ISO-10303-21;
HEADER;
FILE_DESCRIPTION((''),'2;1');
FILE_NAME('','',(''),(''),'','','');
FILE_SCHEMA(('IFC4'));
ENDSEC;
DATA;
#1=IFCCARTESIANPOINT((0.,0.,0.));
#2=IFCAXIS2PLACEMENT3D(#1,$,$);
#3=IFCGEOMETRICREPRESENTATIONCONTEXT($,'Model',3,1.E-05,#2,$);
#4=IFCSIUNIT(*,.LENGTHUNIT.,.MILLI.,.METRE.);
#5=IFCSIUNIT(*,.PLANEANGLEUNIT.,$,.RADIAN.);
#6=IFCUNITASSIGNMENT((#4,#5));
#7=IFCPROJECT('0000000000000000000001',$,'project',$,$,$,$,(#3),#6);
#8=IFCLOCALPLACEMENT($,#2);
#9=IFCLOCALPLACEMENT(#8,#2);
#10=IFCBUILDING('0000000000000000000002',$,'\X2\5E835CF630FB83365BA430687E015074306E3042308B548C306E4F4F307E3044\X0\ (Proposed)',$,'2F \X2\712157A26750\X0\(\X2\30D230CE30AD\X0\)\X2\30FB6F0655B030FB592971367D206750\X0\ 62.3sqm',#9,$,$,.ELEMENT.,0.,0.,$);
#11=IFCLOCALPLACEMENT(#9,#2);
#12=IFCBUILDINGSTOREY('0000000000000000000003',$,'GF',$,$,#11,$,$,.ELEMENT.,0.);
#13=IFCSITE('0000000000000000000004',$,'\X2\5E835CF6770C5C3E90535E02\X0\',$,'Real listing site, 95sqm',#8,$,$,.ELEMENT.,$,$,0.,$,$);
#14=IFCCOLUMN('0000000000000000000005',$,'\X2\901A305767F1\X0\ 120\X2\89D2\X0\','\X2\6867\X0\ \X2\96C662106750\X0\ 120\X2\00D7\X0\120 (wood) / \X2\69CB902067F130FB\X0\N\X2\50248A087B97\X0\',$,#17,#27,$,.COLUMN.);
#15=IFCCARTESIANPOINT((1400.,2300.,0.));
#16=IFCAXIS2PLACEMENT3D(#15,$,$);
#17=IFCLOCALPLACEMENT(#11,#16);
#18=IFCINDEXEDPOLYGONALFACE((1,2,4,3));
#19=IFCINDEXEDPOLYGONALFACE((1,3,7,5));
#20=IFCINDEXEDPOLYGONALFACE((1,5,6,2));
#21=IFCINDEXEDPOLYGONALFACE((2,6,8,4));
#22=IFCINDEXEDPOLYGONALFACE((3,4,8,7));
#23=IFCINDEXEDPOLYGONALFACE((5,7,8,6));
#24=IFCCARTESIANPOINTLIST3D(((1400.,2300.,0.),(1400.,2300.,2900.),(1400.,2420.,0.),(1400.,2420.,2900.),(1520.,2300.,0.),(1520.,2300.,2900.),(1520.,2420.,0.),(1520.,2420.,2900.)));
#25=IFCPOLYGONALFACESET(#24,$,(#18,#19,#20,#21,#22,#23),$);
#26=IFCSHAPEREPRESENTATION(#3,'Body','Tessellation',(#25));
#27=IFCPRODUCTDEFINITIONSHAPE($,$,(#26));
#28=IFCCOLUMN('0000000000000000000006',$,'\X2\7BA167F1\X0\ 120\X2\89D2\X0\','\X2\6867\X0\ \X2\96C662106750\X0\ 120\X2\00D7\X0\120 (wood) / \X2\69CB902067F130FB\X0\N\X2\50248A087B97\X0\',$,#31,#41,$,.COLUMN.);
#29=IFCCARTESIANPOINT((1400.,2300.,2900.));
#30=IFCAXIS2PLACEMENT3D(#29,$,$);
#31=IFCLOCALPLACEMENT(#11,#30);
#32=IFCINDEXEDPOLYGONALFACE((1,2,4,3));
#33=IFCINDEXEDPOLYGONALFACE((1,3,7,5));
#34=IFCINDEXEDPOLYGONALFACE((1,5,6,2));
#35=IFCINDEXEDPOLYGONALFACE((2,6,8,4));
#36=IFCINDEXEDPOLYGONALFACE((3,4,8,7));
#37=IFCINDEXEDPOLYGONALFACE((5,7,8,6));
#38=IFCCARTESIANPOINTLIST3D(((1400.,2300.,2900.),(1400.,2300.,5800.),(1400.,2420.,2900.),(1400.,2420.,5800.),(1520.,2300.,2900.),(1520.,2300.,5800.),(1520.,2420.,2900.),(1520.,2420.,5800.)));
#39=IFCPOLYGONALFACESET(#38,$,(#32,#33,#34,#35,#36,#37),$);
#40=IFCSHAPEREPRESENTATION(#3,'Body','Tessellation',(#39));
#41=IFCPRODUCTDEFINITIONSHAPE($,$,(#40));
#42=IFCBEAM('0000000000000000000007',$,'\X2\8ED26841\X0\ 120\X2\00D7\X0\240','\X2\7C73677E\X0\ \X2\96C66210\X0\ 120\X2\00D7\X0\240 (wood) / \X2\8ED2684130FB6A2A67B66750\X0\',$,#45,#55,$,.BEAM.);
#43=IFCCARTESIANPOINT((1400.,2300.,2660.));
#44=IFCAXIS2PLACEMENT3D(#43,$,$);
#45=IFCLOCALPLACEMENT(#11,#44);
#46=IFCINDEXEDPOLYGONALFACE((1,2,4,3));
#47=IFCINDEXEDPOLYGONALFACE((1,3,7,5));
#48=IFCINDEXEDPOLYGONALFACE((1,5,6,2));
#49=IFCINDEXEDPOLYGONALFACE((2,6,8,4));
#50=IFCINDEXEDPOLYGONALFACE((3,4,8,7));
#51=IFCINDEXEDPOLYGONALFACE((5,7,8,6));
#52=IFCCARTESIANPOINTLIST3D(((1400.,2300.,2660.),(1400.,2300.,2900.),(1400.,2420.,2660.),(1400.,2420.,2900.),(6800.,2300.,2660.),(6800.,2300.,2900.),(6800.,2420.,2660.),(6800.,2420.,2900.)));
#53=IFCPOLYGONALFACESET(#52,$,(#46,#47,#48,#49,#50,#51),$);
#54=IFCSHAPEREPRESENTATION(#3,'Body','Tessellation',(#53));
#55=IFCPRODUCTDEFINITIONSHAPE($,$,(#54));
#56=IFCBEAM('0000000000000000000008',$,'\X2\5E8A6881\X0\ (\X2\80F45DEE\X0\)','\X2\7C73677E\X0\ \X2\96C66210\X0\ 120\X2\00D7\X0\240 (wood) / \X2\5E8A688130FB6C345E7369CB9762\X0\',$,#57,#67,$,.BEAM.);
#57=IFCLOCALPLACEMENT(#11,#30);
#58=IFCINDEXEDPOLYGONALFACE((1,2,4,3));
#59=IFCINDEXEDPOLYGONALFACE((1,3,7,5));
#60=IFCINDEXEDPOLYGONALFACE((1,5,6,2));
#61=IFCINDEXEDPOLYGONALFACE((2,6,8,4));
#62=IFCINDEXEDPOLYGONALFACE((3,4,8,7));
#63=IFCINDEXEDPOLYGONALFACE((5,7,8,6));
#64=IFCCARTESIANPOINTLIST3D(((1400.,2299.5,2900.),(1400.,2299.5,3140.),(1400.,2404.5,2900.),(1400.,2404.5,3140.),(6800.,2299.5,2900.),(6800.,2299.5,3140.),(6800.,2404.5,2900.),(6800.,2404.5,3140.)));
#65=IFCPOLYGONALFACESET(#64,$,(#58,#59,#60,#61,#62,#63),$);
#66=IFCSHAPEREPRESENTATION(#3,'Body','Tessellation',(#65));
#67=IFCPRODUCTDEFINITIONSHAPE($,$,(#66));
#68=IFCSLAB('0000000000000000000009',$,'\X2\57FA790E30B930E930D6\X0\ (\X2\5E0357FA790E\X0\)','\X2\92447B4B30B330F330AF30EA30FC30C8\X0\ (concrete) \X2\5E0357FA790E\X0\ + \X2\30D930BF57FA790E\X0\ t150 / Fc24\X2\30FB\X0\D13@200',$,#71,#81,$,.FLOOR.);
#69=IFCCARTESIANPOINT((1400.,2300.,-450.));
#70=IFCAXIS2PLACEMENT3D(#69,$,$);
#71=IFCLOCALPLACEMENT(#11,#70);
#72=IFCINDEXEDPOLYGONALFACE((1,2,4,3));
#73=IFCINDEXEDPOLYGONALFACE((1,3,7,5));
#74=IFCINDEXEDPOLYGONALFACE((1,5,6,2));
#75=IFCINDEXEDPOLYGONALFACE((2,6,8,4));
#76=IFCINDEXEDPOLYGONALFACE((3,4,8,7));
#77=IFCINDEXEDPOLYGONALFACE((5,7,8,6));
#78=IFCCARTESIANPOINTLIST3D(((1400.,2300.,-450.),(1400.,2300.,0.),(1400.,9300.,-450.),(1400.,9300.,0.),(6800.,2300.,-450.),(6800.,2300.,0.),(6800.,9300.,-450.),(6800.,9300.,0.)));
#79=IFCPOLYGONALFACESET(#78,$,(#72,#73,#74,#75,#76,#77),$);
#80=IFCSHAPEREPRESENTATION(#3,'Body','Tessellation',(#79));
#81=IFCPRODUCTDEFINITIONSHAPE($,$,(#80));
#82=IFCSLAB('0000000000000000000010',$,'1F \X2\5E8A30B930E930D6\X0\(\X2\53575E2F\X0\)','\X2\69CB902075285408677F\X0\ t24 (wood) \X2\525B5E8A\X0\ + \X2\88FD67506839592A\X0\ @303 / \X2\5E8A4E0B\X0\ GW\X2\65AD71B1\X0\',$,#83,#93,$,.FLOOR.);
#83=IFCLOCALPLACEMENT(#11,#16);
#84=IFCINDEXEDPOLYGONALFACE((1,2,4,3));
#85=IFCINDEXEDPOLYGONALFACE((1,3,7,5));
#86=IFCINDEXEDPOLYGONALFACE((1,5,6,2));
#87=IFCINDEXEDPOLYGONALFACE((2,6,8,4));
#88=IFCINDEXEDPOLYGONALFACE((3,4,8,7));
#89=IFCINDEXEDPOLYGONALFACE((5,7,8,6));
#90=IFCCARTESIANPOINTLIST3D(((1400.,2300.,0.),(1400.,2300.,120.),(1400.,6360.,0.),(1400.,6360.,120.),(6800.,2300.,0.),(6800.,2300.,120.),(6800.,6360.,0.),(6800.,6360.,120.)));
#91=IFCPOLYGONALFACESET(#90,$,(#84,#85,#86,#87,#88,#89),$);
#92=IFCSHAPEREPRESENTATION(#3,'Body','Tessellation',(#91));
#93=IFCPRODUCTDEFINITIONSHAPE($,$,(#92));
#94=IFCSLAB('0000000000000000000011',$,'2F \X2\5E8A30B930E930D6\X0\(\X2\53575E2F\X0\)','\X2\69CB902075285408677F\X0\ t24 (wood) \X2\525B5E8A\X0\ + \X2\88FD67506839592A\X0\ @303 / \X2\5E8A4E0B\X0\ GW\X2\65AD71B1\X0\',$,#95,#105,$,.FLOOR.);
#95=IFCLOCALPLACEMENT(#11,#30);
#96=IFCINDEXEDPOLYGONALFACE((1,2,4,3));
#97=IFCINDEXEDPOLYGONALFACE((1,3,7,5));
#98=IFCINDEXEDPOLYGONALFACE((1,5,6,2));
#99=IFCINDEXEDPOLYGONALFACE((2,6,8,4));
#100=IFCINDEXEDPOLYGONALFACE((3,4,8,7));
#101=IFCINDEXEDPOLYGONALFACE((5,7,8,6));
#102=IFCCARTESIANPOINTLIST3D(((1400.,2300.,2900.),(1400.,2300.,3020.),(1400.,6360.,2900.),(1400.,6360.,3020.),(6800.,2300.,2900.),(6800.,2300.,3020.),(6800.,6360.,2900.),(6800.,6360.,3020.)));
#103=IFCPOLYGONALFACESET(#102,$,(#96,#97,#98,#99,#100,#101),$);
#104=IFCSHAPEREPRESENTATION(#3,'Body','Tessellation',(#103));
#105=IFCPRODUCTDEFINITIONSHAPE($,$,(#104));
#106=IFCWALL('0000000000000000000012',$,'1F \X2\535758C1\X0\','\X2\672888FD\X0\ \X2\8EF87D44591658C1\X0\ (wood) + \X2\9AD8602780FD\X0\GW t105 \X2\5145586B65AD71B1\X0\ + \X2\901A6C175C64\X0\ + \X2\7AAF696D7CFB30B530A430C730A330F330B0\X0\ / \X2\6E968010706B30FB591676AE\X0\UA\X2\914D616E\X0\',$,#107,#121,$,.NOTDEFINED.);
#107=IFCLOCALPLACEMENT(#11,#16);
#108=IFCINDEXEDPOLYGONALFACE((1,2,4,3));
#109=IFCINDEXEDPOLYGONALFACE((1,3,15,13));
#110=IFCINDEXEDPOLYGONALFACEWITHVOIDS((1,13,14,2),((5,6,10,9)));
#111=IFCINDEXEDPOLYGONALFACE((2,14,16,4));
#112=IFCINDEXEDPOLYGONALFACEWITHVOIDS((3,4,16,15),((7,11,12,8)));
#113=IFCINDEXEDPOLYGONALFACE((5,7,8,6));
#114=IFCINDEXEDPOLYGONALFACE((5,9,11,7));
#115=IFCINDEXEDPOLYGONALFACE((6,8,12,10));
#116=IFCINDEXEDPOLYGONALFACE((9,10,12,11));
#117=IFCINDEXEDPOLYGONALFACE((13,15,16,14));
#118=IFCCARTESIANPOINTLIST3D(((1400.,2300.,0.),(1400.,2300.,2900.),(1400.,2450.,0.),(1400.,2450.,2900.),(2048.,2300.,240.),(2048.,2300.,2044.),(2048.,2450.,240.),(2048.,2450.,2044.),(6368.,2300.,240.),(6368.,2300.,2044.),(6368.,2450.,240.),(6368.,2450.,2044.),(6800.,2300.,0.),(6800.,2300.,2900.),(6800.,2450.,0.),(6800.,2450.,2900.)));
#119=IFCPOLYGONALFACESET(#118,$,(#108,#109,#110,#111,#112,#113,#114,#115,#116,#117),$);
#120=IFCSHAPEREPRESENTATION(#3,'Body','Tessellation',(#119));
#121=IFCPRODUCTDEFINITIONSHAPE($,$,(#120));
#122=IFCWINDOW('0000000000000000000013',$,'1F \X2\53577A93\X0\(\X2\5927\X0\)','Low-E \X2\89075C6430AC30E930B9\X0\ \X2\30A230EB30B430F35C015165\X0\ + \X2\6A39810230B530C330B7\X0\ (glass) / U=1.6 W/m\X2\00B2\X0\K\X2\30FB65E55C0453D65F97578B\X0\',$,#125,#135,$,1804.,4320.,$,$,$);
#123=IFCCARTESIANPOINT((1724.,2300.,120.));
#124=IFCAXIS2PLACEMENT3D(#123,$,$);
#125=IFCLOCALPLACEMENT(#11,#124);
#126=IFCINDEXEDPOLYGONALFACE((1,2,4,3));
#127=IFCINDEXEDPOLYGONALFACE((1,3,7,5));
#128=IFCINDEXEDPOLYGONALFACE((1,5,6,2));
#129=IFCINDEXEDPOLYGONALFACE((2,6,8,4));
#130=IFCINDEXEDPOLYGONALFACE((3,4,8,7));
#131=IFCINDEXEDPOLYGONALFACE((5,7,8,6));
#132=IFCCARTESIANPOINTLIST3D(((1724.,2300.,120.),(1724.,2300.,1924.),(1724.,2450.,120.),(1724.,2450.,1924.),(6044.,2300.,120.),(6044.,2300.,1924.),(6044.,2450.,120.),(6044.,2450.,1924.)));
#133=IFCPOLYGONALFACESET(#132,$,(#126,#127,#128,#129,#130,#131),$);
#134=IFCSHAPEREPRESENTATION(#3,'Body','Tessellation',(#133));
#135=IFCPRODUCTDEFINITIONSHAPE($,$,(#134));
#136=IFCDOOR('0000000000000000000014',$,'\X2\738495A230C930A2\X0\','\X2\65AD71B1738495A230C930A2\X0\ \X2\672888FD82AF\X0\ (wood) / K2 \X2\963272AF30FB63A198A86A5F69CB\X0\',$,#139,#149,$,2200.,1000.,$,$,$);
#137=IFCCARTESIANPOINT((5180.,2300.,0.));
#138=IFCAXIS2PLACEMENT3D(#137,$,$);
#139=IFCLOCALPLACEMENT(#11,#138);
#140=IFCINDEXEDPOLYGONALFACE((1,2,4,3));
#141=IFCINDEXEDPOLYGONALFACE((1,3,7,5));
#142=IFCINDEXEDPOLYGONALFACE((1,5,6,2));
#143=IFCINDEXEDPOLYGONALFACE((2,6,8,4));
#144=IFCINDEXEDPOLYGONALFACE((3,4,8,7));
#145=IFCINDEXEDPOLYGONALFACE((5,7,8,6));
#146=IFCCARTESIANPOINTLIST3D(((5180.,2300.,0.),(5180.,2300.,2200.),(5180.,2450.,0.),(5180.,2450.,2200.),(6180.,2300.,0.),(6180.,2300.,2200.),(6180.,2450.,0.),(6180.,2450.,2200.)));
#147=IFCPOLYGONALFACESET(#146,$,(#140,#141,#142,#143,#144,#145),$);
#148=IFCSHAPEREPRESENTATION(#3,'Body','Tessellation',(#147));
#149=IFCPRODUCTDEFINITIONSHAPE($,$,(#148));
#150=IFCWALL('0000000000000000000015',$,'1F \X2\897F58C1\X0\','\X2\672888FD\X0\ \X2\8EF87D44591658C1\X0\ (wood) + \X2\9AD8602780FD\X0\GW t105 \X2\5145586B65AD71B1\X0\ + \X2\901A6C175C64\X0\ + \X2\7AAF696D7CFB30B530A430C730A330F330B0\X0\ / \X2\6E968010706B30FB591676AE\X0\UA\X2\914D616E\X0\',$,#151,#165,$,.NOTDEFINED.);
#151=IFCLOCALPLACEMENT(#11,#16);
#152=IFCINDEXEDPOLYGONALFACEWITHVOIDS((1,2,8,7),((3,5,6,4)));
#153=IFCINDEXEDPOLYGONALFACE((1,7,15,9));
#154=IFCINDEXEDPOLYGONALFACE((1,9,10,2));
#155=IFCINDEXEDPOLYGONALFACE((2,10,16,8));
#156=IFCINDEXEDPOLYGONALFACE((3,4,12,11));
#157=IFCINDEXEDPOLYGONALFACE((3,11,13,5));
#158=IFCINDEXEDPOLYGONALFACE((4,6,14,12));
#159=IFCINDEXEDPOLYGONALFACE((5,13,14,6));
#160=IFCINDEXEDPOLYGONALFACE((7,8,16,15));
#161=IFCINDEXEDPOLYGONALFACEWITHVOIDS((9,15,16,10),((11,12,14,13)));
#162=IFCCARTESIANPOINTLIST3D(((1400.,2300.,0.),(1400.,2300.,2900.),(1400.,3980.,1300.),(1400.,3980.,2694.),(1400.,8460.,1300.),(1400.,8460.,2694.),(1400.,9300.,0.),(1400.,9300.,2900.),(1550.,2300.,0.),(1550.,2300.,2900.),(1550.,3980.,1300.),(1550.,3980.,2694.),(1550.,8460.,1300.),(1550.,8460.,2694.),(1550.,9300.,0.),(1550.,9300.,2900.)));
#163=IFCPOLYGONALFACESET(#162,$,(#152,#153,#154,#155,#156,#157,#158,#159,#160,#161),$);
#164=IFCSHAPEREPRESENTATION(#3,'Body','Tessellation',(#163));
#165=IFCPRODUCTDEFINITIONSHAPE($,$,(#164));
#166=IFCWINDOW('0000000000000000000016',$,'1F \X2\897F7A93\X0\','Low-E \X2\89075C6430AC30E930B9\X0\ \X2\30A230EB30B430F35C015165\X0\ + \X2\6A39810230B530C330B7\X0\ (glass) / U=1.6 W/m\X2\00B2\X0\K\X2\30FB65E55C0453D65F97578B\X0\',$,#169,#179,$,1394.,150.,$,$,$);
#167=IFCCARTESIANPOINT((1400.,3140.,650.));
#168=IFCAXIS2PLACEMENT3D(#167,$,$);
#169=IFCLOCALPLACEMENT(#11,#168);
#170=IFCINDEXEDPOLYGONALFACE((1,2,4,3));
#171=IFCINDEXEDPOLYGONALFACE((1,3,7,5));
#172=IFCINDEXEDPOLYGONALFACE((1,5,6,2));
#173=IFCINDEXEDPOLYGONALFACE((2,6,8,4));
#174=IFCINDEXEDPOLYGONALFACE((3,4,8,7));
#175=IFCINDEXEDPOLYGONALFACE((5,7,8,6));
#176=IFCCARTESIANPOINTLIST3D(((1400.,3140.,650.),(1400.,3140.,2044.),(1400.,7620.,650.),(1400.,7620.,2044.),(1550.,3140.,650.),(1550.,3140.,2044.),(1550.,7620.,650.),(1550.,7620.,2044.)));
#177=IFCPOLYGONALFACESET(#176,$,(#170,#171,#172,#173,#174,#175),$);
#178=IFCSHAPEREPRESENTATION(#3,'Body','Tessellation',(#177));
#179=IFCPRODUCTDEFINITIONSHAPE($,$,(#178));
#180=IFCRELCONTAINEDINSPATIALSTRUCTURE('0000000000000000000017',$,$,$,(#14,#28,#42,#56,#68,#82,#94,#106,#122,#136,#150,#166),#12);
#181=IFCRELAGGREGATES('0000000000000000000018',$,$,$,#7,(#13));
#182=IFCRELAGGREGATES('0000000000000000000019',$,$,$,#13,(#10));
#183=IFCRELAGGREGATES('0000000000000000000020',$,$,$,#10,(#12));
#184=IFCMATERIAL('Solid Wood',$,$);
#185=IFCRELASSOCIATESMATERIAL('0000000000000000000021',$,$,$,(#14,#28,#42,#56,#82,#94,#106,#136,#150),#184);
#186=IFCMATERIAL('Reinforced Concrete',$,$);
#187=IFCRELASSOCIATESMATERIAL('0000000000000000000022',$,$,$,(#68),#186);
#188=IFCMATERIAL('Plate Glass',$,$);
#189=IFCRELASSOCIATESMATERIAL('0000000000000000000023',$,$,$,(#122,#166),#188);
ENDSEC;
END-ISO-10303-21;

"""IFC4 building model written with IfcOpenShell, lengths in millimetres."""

from ifc_helpers import new_model, si_unit, frame, frame_2d, origin, place, context, project, spatial, rectangle, extrude, material, element, fill, save


model = new_model("IFC4")

# Units and contexts
model_context = context("Model", 3, precision=1e-05, world=origin())
ifc_project = project(units=[si_unit("LENGTHUNIT", "METRE", prefix="MILLI"), si_unit("PLANEANGLEUNIT", "RADIAN")], contexts=[model_context])

# Site, building, storey
site_placement = place(None, origin())
site = spatial("IfcSite", under=ifc_project, at=site_placement, Name="広島県尾道市", ObjectType="Real listing site, 95sqm", CompositionType="ELEMENT", RefElevation=0.0)
building_placement = place(site_placement, origin())
building = spatial("IfcBuilding", under=site, at=building_placement, Name="広島・茶室と縁側のある和の住まい (Proposed)", ObjectType="2F 無垢材(ヒノキ)・漆喰・天然素材 62.3sqm", CompositionType="ELEMENT", ElevationOfRefHeight=0.0, ElevationOfTerrain=0.0)
storey_placement = place(building_placement, origin())
storey = spatial("IfcBuildingStorey", under=building, at=storey_placement, Name="GF", CompositionType="ELEMENT", Elevation=0.0)

# Columns
ifc_material_1 = material(Name="Solid Wood")
column_1_placement = place(storey_placement, frame((1400.0, 2300.0, 0.0)))
element("IfcColumn", 1, at=column_1_placement, inside=storey, material=ifc_material_1, Name="通し柱 120角", Description="桧 集成材 120×120 (wood) / 構造柱・N値計算", PredefinedType="COLUMN", context=model_context, shape_type="SweptSolid", body=[
    extrude(rectangle(XDim=120.0, YDim=120.0, at=frame_2d((60.0, 60.0))), frame((1400.0, 2300.0, 0.0)), (0.0, 0.0, 1.0), 2900.0),
])
column_2_placement = place(storey_placement, frame((1400.0, 2300.0, 2900.0)))
element("IfcColumn", 2, at=column_2_placement, inside=storey, material=ifc_material_1, Name="管柱 120角", Description="桧 集成材 120×120 (wood) / 構造柱・N値計算", PredefinedType="COLUMN", context=model_context, shape_type="SweptSolid", body=[
    extrude(rectangle(XDim=120.0, YDim=120.0, at=frame_2d((60.0, 60.0))), frame((1400.0, 2300.0, 2900.0)), (0.0, 0.0, 1.0), 2900.0),
])

# Beams
beam_1_placement = place(storey_placement, frame((1400.0, 2300.0, 2660.0)))
element("IfcBeam", 3, at=beam_1_placement, inside=storey, material=ifc_material_1, Name="軒桁 120×240", Description="米松 集成 120×240 (wood) / 軒桁・横架材", PredefinedType="BEAM", context=model_context, shape_type="SweptSolid", body=[
    extrude(rectangle(XDim=5400.0, YDim=120.0, at=frame_2d((2700.0, 60.0))), frame((1400.0, 2300.0, 2660.0)), (0.0, 0.0, 1.0), 240.0),
])
beam_2_placement = place(storey_placement, frame((1400.0, 2300.0, 2900.0)))
element("IfcBeam", 4, at=beam_2_placement, inside=storey, material=ifc_material_1, Name="床梁 (胴差)", Description="米松 集成 120×240 (wood) / 床梁・水平構面", PredefinedType="BEAM", context=model_context, shape_type="SweptSolid", body=[
    extrude(rectangle(XDim=5400.0, YDim=105.0, at=frame_2d((2700.0, 52.0))), frame((1400.0, 2300.0, 2900.0)), (0.0, 0.0, 1.0), 240.0),
])

# Slabs
ifc_material_2 = material(Name="Reinforced Concrete")
slab_1_placement = place(storey_placement, frame((1400.0, 2300.0, -450.0)))
element("IfcSlab", 5, at=slab_1_placement, inside=storey, material=ifc_material_2, Name="基礎スラブ (布基礎)", Description="鉄筋コンクリート (concrete) 布基礎 + ベタ基礎 t150 / Fc24・D13@200", PredefinedType="FLOOR", context=model_context, shape_type="SweptSolid", body=[
    extrude(rectangle(XDim=5400.0, YDim=7000.0, at=frame_2d((2700.0, 3500.0))), frame((1400.0, 2300.0, -450.0)), (0.0, 0.0, 1.0), 450.0),
])
slab_2_placement = place(storey_placement, frame((1400.0, 2300.0, 0.0)))
element("IfcSlab", 6, at=slab_2_placement, inside=storey, material=ifc_material_1, Name="1F 床スラブ(南帯)", Description="構造用合板 t24 (wood) 剛床 + 製材根太 @303 / 床下 GW断熱", PredefinedType="FLOOR", context=model_context, shape_type="SweptSolid", body=[
    extrude(rectangle(XDim=5400.0, YDim=4060.0, at=frame_2d((2700.0, 2030.0))), frame((1400.0, 2300.0, 0.0)), (0.0, 0.0, 1.0), 120.0),
])
slab_3_placement = place(storey_placement, frame((1400.0, 2300.0, 2900.0)))
element("IfcSlab", 7, at=slab_3_placement, inside=storey, material=ifc_material_1, Name="2F 床スラブ(南帯)", Description="構造用合板 t24 (wood) 剛床 + 製材根太 @303 / 床下 GW断熱", PredefinedType="FLOOR", context=model_context, shape_type="SweptSolid", body=[
    extrude(rectangle(XDim=5400.0, YDim=4060.0, at=frame_2d((2700.0, 2030.0))), frame((1400.0, 2300.0, 2900.0)), (0.0, 0.0, 1.0), 120.0),
])

# Wall, openings, window, door
wall_1_placement = place(storey_placement, frame((1400.0, 2300.0, 0.0)))
wall_1 = element("IfcWall", 8, at=wall_1_placement, inside=storey, material=ifc_material_1, Name="1F 南壁", Description="木製 軸組外壁 (wood) + 高性能GW t105 充填断熱 + 通気層 + 窯業系サイディング / 準耐火・外皮UA配慮", PredefinedType="NOTDEFINED", context=model_context, shape_type="SweptSolid", body=[
    extrude(rectangle(XDim=5400.0, YDim=150.0, at=frame_2d((2700.0, 75.0))), frame((1400.0, 2300.0, 0.0)), (0.0, 0.0, 1.0), 2900.0),
])
opening_1_placement = place(storey_placement, frame((1724.0, 2300.0, 120.0)))
opening_1 = element("IfcOpeningElement", 9, at=opening_1_placement, cuts=wall_1, PredefinedType="NOTDEFINED", context=model_context, shape_type="SweptSolid", body=[
    extrude(rectangle(XDim=4320.0, YDim=150.0, at=frame_2d((2160.0, 75.0))), frame((1724.0, 2300.0, 120.0)), (0.0, 0.0, 1.0), 1804.0),
])
opening_2_placement = place(storey_placement, frame((5180.0, 2300.0, 0.0)))
opening_2 = element("IfcOpeningElement", 10, at=opening_2_placement, cuts=wall_1, PredefinedType="NOTDEFINED", context=model_context, shape_type="SweptSolid", body=[
    extrude(rectangle(XDim=1000.0, YDim=150.0, at=frame_2d((500.0, 75.0))), frame((5180.0, 2300.0, 0.0)), (0.0, 0.0, 1.0), 2200.0),
])
ifc_material_3 = material(Name="Plate Glass")
window_1_placement = place(storey_placement, frame((1724.0, 2300.0, 120.0)))
window_1 = element("IfcWindow", 11, at=window_1_placement, inside=storey, material=ifc_material_3, Name="1F 南窓(大)", Description="Low-E 複層ガラス アルゴン封入 + 樹脂サッシ (glass) / U=1.6 W/m²K・日射取得型", OverallHeight=1804.0, OverallWidth=4320.0, context=model_context, shape_type="SweptSolid", body=[
    extrude(rectangle(XDim=4320.0, YDim=150.0, at=frame_2d((2160.0, 75.0))), frame((1724.0, 2300.0, 120.0)), (0.0, 0.0, 1.0), 1804.0),
])
fill(opening_1, window_1)
door_placement = place(storey_placement, frame((5180.0, 2300.0, 0.0)))
door = element("IfcDoor", 12, at=door_placement, inside=storey, material=ifc_material_1, Name="玄関ドア", Description="断熱玄関ドア 木製芯 (wood) / K2 防犯・採風機構", OverallHeight=2200.0, OverallWidth=1000.0, context=model_context, shape_type="SweptSolid", body=[
    extrude(rectangle(XDim=1000.0, YDim=150.0, at=frame_2d((500.0, 75.0))), frame((5180.0, 2300.0, 0.0)), (0.0, 0.0, 1.0), 2200.0),
])
fill(opening_2, door)

# Wall, opening, window
wall_2_placement = place(storey_placement, frame((1400.0, 2300.0, 0.0)))
wall_2 = element("IfcWall", 13, at=wall_2_placement, inside=storey, material=ifc_material_1, Name="1F 西壁", Description="木製 軸組外壁 (wood) + 高性能GW t105 充填断熱 + 通気層 + 窯業系サイディング / 準耐火・外皮UA配慮", PredefinedType="NOTDEFINED", context=model_context, shape_type="SweptSolid", body=[
    extrude(rectangle(XDim=150.0, YDim=7000.0, at=frame_2d((75.0, 3500.0))), frame((1400.0, 2300.0, 0.0)), (0.0, 0.0, 1.0), 2900.0),
])
opening_3_placement = place(storey_placement, frame((1400.0, 3140.0, 650.0)))
opening_3 = element("IfcOpeningElement", 14, at=opening_3_placement, cuts=wall_2, PredefinedType="NOTDEFINED", context=model_context, shape_type="SweptSolid", body=[
    extrude(rectangle(XDim=150.0, YDim=4480.0, at=frame_2d((75.0, 2240.0))), frame((1400.0, 3140.0, 650.0)), (0.0, 0.0, 1.0), 1394.0),
])
window_2_placement = place(storey_placement, frame((1400.0, 3140.0, 650.0)))
window_2 = element("IfcWindow", 15, at=window_2_placement, inside=storey, material=ifc_material_3, Name="1F 西窓", Description="Low-E 複層ガラス アルゴン封入 + 樹脂サッシ (glass) / U=1.6 W/m²K・日射取得型", OverallHeight=1394.0, OverallWidth=150.0, context=model_context, shape_type="SweptSolid", body=[
    extrude(rectangle(XDim=150.0, YDim=4480.0, at=frame_2d((75.0, 2240.0))), frame((1400.0, 3140.0, 650.0)), (0.0, 0.0, 1.0), 1394.0),
])
fill(opening_3, window_2)

save(model, "model.ifc")
